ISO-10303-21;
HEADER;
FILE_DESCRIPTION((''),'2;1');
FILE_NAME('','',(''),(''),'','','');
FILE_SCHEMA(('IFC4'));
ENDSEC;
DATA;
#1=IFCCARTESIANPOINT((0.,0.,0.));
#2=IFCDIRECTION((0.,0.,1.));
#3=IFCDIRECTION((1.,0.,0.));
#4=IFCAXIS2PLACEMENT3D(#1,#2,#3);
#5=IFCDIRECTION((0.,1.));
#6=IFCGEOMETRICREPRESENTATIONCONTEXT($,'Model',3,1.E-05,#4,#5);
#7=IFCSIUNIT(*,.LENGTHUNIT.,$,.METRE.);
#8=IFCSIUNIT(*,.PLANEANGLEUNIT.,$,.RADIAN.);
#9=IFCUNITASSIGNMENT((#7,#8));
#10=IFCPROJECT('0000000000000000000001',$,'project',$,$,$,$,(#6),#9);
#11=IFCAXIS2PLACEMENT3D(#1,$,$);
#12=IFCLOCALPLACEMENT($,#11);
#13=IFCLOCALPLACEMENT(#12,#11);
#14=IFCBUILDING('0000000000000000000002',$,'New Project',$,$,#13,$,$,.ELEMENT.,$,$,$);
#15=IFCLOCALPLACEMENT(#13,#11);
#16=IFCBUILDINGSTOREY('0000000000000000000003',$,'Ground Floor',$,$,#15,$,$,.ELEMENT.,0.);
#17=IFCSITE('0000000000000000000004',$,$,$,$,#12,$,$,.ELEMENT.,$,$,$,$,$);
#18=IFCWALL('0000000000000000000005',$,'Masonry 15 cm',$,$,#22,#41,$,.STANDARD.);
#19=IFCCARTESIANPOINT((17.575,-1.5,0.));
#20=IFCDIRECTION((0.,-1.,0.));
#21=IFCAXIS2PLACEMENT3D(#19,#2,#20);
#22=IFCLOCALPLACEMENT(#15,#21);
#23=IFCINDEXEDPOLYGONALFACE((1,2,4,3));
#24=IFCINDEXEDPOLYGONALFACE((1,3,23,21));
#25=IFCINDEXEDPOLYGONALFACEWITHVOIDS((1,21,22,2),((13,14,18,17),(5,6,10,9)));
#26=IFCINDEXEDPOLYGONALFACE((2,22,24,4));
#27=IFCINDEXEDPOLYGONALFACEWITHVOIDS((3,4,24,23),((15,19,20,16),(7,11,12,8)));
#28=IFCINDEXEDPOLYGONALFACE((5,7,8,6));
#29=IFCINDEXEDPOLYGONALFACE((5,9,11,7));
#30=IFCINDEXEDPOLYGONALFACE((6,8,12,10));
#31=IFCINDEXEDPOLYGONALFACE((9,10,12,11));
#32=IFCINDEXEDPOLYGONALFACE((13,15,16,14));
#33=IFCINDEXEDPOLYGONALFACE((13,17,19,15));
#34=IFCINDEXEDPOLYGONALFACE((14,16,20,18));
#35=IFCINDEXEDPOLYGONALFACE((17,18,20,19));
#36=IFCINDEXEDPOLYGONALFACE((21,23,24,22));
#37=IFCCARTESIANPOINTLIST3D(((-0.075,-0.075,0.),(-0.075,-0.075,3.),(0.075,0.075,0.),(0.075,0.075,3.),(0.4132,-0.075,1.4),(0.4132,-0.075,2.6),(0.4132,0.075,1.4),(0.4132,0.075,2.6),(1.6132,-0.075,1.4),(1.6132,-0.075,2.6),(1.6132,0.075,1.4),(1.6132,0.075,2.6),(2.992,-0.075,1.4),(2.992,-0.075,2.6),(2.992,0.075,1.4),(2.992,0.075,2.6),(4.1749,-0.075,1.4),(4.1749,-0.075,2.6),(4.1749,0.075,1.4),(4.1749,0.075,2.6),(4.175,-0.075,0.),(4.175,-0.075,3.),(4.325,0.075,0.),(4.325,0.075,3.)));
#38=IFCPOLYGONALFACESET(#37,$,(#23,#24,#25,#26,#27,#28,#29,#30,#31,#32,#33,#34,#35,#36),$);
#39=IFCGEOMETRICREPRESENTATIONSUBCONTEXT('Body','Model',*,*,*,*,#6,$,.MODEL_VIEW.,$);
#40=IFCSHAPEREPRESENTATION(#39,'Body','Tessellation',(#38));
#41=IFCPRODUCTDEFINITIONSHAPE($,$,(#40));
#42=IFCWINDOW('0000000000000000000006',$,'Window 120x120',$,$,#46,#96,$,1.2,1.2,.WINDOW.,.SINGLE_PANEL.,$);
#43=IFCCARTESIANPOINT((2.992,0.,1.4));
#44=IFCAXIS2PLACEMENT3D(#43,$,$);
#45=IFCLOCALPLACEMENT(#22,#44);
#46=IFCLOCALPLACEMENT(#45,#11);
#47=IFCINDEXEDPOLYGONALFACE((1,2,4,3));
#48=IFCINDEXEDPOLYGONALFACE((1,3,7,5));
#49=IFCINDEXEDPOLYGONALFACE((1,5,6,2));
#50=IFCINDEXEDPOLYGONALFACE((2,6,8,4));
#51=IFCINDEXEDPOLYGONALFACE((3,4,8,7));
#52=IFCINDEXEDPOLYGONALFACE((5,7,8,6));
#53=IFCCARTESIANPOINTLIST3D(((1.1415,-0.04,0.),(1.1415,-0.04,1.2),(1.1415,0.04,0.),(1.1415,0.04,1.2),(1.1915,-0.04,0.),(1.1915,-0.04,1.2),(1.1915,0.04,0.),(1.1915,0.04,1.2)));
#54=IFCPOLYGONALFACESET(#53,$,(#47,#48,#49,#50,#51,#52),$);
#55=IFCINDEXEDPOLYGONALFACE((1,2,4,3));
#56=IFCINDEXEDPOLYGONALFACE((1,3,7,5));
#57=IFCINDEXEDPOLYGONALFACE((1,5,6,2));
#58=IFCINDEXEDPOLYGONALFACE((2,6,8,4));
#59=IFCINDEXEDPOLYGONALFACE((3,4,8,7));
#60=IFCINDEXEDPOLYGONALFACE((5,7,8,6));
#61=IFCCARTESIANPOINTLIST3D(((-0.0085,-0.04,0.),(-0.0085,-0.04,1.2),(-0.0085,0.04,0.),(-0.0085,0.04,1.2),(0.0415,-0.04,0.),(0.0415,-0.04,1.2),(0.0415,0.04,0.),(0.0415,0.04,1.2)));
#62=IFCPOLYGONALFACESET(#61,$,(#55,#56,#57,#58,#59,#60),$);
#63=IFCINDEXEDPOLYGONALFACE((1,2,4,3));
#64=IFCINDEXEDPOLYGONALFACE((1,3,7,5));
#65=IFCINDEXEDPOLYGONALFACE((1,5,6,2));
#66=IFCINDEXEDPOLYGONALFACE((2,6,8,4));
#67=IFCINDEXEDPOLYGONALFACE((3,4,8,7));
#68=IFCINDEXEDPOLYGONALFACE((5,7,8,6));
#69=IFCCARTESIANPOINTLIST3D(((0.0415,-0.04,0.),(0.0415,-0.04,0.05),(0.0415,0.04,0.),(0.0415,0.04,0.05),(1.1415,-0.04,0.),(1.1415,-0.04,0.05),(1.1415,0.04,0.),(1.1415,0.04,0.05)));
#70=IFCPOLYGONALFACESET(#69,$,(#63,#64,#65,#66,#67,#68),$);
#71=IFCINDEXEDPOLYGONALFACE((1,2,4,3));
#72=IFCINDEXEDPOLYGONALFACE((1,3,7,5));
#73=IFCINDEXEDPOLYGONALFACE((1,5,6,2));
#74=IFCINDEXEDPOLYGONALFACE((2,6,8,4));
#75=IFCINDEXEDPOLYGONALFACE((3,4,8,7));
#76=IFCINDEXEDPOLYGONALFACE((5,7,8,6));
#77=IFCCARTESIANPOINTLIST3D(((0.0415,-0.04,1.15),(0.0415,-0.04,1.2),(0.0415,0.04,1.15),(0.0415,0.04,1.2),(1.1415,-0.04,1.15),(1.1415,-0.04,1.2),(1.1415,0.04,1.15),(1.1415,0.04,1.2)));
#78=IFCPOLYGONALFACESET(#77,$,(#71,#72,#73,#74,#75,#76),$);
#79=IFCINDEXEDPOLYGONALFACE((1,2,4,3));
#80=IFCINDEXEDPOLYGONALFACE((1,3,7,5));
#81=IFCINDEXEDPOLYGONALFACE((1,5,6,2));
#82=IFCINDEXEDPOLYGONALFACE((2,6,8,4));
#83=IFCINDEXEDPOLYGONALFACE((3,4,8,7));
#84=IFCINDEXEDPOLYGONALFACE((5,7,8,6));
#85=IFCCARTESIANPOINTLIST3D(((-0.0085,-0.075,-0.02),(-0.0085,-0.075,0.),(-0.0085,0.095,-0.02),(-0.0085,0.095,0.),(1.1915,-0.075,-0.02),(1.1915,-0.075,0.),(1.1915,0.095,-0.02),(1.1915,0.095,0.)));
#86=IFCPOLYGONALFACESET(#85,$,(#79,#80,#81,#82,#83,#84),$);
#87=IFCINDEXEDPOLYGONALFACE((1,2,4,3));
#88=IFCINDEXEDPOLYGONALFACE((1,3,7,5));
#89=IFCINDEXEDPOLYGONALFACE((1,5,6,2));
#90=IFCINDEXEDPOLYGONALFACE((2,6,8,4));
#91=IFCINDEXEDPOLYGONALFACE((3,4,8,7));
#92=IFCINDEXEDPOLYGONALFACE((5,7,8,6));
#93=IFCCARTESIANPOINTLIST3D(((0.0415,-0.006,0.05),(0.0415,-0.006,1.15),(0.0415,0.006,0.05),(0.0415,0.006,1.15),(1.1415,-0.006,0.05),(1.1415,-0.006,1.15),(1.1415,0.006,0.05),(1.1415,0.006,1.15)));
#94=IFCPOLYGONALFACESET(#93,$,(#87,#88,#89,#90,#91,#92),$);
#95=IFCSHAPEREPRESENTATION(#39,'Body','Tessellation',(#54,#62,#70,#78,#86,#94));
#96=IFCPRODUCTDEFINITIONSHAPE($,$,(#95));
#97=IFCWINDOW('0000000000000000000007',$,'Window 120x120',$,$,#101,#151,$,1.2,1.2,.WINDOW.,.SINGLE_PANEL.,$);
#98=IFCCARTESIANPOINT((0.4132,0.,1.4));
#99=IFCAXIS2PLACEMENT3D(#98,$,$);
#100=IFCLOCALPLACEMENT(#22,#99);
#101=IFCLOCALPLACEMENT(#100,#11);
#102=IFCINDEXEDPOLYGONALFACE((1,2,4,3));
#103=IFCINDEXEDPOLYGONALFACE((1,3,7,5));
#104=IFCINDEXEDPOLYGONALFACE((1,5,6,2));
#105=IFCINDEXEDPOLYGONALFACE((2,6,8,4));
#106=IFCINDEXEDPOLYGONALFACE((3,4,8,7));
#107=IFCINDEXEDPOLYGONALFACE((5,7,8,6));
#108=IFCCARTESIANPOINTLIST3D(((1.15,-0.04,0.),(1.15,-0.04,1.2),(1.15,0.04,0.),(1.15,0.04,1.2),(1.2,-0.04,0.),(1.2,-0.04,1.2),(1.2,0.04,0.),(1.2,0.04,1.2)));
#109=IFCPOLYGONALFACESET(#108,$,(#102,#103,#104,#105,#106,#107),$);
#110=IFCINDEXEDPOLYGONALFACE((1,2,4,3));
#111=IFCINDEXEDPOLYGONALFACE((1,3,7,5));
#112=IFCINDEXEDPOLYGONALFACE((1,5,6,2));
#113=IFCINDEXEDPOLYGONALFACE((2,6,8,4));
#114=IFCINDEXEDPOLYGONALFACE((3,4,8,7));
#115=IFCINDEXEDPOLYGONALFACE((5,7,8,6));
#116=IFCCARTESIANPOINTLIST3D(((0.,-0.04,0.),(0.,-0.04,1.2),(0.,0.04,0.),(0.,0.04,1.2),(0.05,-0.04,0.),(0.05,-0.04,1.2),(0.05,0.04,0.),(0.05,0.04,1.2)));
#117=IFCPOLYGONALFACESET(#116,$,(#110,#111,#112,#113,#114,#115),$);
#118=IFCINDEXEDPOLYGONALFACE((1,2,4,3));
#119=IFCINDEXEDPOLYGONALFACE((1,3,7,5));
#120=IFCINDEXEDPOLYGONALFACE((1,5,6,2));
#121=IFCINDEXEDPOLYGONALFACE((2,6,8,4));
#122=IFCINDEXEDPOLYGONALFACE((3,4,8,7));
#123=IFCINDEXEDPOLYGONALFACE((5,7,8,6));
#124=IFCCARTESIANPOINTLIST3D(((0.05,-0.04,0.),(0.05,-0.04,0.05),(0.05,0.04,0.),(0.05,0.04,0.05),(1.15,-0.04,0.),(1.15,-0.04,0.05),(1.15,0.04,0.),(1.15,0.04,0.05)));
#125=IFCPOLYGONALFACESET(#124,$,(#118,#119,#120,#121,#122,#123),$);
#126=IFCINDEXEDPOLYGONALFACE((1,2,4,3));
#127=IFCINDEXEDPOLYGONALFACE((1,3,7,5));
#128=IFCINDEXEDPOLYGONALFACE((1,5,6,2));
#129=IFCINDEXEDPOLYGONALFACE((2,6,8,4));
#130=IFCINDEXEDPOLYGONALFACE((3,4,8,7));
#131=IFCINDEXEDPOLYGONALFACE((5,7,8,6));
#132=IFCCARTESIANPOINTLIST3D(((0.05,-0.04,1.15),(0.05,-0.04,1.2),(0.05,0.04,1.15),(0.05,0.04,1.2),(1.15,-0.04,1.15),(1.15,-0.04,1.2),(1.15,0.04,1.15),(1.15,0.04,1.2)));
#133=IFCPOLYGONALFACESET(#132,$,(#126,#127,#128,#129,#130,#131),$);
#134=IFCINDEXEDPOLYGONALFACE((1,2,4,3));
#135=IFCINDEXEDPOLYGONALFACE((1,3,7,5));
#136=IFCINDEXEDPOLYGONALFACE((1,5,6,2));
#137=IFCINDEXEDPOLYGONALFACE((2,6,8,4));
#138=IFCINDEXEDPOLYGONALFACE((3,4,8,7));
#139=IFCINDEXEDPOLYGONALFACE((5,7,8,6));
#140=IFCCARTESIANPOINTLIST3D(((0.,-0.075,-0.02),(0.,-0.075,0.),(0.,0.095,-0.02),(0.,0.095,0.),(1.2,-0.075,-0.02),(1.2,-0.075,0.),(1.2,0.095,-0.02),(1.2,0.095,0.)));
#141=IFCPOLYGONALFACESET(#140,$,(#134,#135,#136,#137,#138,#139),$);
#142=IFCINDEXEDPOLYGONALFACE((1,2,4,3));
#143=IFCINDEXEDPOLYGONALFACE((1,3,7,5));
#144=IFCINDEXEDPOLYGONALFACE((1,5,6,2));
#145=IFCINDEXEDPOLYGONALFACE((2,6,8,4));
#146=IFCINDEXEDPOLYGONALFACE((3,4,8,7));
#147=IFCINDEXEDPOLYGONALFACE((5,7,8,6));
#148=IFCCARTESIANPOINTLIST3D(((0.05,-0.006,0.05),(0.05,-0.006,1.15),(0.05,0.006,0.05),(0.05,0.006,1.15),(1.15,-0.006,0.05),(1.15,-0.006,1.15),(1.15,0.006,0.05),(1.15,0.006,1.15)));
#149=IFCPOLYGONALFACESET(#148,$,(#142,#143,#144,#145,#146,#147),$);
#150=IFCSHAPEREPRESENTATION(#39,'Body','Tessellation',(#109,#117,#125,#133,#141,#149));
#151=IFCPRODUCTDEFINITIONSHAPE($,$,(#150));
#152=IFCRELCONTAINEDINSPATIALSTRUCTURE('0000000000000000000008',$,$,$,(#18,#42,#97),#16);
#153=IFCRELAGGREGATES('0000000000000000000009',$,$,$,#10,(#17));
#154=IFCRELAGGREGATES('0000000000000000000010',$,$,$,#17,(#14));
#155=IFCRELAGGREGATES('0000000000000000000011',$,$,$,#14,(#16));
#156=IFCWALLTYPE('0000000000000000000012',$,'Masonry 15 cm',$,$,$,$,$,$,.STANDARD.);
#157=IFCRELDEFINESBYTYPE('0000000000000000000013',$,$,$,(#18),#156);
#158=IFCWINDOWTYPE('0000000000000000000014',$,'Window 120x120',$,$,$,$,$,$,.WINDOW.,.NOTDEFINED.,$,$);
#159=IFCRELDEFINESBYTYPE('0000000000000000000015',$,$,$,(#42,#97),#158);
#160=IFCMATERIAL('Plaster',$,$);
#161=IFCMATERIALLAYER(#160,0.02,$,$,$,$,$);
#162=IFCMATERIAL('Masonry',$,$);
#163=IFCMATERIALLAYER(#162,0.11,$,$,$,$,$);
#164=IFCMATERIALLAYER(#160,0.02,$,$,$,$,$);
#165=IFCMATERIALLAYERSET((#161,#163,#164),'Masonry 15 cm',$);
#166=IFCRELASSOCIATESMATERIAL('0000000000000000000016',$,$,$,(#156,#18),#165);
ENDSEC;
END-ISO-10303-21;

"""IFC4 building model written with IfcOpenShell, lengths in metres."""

from ifc_helpers import new_model, si_unit, direction, frame, frame_2d, origin, origin_with_axes, place, context, subcontext, project, spatial, polyline, rectangle, outline, extrude, material, layer, layer_set, layer_usage, type_object, element, fill, save


model = new_model("IFC4")

# Units and contexts
model_context = context("Model", 3, precision=1e-05, world=origin_with_axes(), true_north=direction((0.0, 1.0)))
body_context = subcontext(model_context, "Body", "Model", "MODEL_VIEW")
ifc_project = project(units=[si_unit("LENGTHUNIT", "METRE"), si_unit("PLANEANGLEUNIT", "RADIAN")], contexts=[model_context])

# Site, building, storey
site_placement = place(None, origin())
site = spatial("IfcSite", under=ifc_project, at=site_placement, CompositionType="ELEMENT")
building_placement = place(site_placement, origin())
building = spatial("IfcBuilding", under=site, at=building_placement, Name="New Project", CompositionType="ELEMENT")
storey_placement = place(building_placement, origin())
storey = spatial("IfcBuildingStorey", under=building, at=storey_placement, Name="Ground Floor", CompositionType="ELEMENT", Elevation=0.0)

# Shared definitions
ifc_material_1 = material(Name="Plaster")
ifc_layer_1 = layer(ifc_material_1, 0.02)
ifc_material_2 = material(Name="Masonry")
ifc_layer_2 = layer(ifc_material_2, 0.11)
ifc_layer_3 = layer(ifc_material_1, 0.02)
ifc_layer_set_1 = layer_set([ifc_layer_1, ifc_layer_2, ifc_layer_3], Name="Masonry 15 cm")
ifc_layer_usage_1 = layer_usage(ifc_layer_set_1, "AXIS2", "NEGATIVE", 0.075)
wall_type_1 = type_object("IfcWallType", Name="Masonry 15 cm", PredefinedType="STANDARD", material=ifc_layer_set_1)
window_type_1 = type_object("IfcWindowType", Name="Window 120x120", PartitioningType="NOTDEFINED", PredefinedType="WINDOW")

# Wall, openings, windows
wall_1_placement = place(storey_placement, frame((17.575, -1.5, 0.0), z_axis=(0.0, 0.0, 1.0), x_axis=(0.0, -1.0, 0.0)))
wall_1 = element("IfcWall", 1, at=wall_1_placement, inside=storey, type_object=wall_type_1, material=ifc_layer_usage_1, Name="Masonry 15 cm", PredefinedType="STANDARD", context=body_context, shape_type="SweptSolid", body=[
    extrude(outline(polyline([(-0.075, -0.075), (4.175, -0.075), (4.325, 0.075), (0.075, 0.075), (-0.075, -0.075)])), origin(), (0.0, 0.0, 1.0), 3.0),
])
opening_1_placement = place(wall_1_placement, frame((2.992, 0.0, 1.4)))
opening_1 = element("IfcOpeningElement", 2, at=opening_1_placement, cuts=wall_1, PredefinedType="OPENING", context=body_context, shape_type="SweptSolid", body=[
    extrude(rectangle(XDim=1.1829, YDim=0.25, at=frame_2d((0.5915, 0.0))), origin(), (0.0, 0.0, 1.0), 1.2),
])
opening_2_placement = place(wall_1_placement, frame((0.4132, 0.0, 1.4)))
opening_2 = element("IfcOpeningElement", 3, at=opening_2_placement, cuts=wall_1, PredefinedType="OPENING", context=body_context, shape_type="SweptSolid", body=[
    extrude(rectangle(XDim=1.2, YDim=0.25, at=frame_2d((0.6, 0.0))), origin(), (0.0, 0.0, 1.0), 1.2),
])
window_1_placement = place(opening_1_placement, origin())
window_1 = element("IfcWindow", 4, at=window_1_placement, inside=storey, type_object=window_type_1, Name="Window 120x120", OverallHeight=1.2, OverallWidth=1.2, PartitioningType="SINGLE_PANEL", PredefinedType="WINDOW", context=body_context, shape_type="SweptSolid", body=[
    extrude(outline(polyline([(1.1915, 0.04), (1.1415, 0.04), (1.1415, -0.04), (1.1915, -0.04), (1.1915, 0.04)])), origin(), (0.0, 0.0, 1.0), 1.2),
    extrude(outline(polyline([(0.0415, 0.04), (-0.0085, 0.04), (-0.0085, -0.04), (0.0415, -0.04), (0.0415, 0.04)])), origin(), (0.0, 0.0, 1.0), 1.2),
    extrude(outline(polyline([(1.1415, 0.04), (0.0415, 0.04), (0.0415, -0.04), (1.1415, -0.04), (1.1415, 0.04)])), origin(), (0.0, 0.0, 1.0), 0.05),
    extrude(outline(polyline([(1.1415, 0.04), (0.0415, 0.04), (0.0415, -0.04), (1.1415, -0.04), (1.1415, 0.04)])), frame((0.0, 0.0, 1.15)), (0.0, 0.0, 1.0), 0.05),
    extrude(outline(polyline([(1.1915, 0.095), (-0.0085, 0.095), (-0.0085, -0.075), (1.1915, -0.075), (1.1915, 0.095)])), frame((0.0, 0.0, -0.02)), (0.0, 0.0, 1.0), 0.02),
    extrude(outline(polyline([(1.1415, 0.006), (0.0415, 0.006), (0.0415, -0.006), (1.1415, -0.006), (1.1415, 0.006)])), frame((0.0, 0.0, 0.05)), (0.0, 0.0, 1.0), 1.1),
])
fill(opening_1, window_1)
window_2_placement = place(opening_2_placement, origin())
window_2 = element("IfcWindow", 5, at=window_2_placement, inside=storey, type_object=window_type_1, Name="Window 120x120", OverallHeight=1.2, OverallWidth=1.2, PartitioningType="SINGLE_PANEL", PredefinedType="WINDOW", context=body_context, shape_type="SweptSolid", body=[
    extrude(outline(polyline([(1.2, 0.04), (1.15, 0.04), (1.15, -0.04), (1.2, -0.04), (1.2, 0.04)])), origin(), (0.0, 0.0, 1.0), 1.2),
    extrude(outline(polyline([(0.05, 0.04), (0.0, 0.04), (0.0, -0.04), (0.05, -0.04), (0.05, 0.04)])), origin(), (0.0, 0.0, 1.0), 1.2),
    extrude(outline(polyline([(1.15, 0.04), (0.05, 0.04), (0.05, -0.04), (1.15, -0.04), (1.15, 0.04)])), origin(), (0.0, 0.0, 1.0), 0.05),
    extrude(outline(polyline([(1.15, 0.04), (0.05, 0.04), (0.05, -0.04), (1.15, -0.04), (1.15, 0.04)])), frame((0.0, 0.0, 1.15)), (0.0, 0.0, 1.0), 0.05),
    extrude(outline(polyline([(1.2, 0.095), (0.0, 0.095), (0.0, -0.075), (1.2, -0.075), (1.2, 0.095)])), frame((0.0, 0.0, -0.02)), (0.0, 0.0, 1.0), 0.02),
    extrude(outline(polyline([(1.15, 0.006), (0.05, 0.006), (0.05, -0.006), (1.15, -0.006), (1.15, 0.006)])), frame((0.0, 0.0, 0.05)), (0.0, 0.0, 1.0), 1.1),
])
fill(opening_2, window_2)

save(model, "model.ifc")
